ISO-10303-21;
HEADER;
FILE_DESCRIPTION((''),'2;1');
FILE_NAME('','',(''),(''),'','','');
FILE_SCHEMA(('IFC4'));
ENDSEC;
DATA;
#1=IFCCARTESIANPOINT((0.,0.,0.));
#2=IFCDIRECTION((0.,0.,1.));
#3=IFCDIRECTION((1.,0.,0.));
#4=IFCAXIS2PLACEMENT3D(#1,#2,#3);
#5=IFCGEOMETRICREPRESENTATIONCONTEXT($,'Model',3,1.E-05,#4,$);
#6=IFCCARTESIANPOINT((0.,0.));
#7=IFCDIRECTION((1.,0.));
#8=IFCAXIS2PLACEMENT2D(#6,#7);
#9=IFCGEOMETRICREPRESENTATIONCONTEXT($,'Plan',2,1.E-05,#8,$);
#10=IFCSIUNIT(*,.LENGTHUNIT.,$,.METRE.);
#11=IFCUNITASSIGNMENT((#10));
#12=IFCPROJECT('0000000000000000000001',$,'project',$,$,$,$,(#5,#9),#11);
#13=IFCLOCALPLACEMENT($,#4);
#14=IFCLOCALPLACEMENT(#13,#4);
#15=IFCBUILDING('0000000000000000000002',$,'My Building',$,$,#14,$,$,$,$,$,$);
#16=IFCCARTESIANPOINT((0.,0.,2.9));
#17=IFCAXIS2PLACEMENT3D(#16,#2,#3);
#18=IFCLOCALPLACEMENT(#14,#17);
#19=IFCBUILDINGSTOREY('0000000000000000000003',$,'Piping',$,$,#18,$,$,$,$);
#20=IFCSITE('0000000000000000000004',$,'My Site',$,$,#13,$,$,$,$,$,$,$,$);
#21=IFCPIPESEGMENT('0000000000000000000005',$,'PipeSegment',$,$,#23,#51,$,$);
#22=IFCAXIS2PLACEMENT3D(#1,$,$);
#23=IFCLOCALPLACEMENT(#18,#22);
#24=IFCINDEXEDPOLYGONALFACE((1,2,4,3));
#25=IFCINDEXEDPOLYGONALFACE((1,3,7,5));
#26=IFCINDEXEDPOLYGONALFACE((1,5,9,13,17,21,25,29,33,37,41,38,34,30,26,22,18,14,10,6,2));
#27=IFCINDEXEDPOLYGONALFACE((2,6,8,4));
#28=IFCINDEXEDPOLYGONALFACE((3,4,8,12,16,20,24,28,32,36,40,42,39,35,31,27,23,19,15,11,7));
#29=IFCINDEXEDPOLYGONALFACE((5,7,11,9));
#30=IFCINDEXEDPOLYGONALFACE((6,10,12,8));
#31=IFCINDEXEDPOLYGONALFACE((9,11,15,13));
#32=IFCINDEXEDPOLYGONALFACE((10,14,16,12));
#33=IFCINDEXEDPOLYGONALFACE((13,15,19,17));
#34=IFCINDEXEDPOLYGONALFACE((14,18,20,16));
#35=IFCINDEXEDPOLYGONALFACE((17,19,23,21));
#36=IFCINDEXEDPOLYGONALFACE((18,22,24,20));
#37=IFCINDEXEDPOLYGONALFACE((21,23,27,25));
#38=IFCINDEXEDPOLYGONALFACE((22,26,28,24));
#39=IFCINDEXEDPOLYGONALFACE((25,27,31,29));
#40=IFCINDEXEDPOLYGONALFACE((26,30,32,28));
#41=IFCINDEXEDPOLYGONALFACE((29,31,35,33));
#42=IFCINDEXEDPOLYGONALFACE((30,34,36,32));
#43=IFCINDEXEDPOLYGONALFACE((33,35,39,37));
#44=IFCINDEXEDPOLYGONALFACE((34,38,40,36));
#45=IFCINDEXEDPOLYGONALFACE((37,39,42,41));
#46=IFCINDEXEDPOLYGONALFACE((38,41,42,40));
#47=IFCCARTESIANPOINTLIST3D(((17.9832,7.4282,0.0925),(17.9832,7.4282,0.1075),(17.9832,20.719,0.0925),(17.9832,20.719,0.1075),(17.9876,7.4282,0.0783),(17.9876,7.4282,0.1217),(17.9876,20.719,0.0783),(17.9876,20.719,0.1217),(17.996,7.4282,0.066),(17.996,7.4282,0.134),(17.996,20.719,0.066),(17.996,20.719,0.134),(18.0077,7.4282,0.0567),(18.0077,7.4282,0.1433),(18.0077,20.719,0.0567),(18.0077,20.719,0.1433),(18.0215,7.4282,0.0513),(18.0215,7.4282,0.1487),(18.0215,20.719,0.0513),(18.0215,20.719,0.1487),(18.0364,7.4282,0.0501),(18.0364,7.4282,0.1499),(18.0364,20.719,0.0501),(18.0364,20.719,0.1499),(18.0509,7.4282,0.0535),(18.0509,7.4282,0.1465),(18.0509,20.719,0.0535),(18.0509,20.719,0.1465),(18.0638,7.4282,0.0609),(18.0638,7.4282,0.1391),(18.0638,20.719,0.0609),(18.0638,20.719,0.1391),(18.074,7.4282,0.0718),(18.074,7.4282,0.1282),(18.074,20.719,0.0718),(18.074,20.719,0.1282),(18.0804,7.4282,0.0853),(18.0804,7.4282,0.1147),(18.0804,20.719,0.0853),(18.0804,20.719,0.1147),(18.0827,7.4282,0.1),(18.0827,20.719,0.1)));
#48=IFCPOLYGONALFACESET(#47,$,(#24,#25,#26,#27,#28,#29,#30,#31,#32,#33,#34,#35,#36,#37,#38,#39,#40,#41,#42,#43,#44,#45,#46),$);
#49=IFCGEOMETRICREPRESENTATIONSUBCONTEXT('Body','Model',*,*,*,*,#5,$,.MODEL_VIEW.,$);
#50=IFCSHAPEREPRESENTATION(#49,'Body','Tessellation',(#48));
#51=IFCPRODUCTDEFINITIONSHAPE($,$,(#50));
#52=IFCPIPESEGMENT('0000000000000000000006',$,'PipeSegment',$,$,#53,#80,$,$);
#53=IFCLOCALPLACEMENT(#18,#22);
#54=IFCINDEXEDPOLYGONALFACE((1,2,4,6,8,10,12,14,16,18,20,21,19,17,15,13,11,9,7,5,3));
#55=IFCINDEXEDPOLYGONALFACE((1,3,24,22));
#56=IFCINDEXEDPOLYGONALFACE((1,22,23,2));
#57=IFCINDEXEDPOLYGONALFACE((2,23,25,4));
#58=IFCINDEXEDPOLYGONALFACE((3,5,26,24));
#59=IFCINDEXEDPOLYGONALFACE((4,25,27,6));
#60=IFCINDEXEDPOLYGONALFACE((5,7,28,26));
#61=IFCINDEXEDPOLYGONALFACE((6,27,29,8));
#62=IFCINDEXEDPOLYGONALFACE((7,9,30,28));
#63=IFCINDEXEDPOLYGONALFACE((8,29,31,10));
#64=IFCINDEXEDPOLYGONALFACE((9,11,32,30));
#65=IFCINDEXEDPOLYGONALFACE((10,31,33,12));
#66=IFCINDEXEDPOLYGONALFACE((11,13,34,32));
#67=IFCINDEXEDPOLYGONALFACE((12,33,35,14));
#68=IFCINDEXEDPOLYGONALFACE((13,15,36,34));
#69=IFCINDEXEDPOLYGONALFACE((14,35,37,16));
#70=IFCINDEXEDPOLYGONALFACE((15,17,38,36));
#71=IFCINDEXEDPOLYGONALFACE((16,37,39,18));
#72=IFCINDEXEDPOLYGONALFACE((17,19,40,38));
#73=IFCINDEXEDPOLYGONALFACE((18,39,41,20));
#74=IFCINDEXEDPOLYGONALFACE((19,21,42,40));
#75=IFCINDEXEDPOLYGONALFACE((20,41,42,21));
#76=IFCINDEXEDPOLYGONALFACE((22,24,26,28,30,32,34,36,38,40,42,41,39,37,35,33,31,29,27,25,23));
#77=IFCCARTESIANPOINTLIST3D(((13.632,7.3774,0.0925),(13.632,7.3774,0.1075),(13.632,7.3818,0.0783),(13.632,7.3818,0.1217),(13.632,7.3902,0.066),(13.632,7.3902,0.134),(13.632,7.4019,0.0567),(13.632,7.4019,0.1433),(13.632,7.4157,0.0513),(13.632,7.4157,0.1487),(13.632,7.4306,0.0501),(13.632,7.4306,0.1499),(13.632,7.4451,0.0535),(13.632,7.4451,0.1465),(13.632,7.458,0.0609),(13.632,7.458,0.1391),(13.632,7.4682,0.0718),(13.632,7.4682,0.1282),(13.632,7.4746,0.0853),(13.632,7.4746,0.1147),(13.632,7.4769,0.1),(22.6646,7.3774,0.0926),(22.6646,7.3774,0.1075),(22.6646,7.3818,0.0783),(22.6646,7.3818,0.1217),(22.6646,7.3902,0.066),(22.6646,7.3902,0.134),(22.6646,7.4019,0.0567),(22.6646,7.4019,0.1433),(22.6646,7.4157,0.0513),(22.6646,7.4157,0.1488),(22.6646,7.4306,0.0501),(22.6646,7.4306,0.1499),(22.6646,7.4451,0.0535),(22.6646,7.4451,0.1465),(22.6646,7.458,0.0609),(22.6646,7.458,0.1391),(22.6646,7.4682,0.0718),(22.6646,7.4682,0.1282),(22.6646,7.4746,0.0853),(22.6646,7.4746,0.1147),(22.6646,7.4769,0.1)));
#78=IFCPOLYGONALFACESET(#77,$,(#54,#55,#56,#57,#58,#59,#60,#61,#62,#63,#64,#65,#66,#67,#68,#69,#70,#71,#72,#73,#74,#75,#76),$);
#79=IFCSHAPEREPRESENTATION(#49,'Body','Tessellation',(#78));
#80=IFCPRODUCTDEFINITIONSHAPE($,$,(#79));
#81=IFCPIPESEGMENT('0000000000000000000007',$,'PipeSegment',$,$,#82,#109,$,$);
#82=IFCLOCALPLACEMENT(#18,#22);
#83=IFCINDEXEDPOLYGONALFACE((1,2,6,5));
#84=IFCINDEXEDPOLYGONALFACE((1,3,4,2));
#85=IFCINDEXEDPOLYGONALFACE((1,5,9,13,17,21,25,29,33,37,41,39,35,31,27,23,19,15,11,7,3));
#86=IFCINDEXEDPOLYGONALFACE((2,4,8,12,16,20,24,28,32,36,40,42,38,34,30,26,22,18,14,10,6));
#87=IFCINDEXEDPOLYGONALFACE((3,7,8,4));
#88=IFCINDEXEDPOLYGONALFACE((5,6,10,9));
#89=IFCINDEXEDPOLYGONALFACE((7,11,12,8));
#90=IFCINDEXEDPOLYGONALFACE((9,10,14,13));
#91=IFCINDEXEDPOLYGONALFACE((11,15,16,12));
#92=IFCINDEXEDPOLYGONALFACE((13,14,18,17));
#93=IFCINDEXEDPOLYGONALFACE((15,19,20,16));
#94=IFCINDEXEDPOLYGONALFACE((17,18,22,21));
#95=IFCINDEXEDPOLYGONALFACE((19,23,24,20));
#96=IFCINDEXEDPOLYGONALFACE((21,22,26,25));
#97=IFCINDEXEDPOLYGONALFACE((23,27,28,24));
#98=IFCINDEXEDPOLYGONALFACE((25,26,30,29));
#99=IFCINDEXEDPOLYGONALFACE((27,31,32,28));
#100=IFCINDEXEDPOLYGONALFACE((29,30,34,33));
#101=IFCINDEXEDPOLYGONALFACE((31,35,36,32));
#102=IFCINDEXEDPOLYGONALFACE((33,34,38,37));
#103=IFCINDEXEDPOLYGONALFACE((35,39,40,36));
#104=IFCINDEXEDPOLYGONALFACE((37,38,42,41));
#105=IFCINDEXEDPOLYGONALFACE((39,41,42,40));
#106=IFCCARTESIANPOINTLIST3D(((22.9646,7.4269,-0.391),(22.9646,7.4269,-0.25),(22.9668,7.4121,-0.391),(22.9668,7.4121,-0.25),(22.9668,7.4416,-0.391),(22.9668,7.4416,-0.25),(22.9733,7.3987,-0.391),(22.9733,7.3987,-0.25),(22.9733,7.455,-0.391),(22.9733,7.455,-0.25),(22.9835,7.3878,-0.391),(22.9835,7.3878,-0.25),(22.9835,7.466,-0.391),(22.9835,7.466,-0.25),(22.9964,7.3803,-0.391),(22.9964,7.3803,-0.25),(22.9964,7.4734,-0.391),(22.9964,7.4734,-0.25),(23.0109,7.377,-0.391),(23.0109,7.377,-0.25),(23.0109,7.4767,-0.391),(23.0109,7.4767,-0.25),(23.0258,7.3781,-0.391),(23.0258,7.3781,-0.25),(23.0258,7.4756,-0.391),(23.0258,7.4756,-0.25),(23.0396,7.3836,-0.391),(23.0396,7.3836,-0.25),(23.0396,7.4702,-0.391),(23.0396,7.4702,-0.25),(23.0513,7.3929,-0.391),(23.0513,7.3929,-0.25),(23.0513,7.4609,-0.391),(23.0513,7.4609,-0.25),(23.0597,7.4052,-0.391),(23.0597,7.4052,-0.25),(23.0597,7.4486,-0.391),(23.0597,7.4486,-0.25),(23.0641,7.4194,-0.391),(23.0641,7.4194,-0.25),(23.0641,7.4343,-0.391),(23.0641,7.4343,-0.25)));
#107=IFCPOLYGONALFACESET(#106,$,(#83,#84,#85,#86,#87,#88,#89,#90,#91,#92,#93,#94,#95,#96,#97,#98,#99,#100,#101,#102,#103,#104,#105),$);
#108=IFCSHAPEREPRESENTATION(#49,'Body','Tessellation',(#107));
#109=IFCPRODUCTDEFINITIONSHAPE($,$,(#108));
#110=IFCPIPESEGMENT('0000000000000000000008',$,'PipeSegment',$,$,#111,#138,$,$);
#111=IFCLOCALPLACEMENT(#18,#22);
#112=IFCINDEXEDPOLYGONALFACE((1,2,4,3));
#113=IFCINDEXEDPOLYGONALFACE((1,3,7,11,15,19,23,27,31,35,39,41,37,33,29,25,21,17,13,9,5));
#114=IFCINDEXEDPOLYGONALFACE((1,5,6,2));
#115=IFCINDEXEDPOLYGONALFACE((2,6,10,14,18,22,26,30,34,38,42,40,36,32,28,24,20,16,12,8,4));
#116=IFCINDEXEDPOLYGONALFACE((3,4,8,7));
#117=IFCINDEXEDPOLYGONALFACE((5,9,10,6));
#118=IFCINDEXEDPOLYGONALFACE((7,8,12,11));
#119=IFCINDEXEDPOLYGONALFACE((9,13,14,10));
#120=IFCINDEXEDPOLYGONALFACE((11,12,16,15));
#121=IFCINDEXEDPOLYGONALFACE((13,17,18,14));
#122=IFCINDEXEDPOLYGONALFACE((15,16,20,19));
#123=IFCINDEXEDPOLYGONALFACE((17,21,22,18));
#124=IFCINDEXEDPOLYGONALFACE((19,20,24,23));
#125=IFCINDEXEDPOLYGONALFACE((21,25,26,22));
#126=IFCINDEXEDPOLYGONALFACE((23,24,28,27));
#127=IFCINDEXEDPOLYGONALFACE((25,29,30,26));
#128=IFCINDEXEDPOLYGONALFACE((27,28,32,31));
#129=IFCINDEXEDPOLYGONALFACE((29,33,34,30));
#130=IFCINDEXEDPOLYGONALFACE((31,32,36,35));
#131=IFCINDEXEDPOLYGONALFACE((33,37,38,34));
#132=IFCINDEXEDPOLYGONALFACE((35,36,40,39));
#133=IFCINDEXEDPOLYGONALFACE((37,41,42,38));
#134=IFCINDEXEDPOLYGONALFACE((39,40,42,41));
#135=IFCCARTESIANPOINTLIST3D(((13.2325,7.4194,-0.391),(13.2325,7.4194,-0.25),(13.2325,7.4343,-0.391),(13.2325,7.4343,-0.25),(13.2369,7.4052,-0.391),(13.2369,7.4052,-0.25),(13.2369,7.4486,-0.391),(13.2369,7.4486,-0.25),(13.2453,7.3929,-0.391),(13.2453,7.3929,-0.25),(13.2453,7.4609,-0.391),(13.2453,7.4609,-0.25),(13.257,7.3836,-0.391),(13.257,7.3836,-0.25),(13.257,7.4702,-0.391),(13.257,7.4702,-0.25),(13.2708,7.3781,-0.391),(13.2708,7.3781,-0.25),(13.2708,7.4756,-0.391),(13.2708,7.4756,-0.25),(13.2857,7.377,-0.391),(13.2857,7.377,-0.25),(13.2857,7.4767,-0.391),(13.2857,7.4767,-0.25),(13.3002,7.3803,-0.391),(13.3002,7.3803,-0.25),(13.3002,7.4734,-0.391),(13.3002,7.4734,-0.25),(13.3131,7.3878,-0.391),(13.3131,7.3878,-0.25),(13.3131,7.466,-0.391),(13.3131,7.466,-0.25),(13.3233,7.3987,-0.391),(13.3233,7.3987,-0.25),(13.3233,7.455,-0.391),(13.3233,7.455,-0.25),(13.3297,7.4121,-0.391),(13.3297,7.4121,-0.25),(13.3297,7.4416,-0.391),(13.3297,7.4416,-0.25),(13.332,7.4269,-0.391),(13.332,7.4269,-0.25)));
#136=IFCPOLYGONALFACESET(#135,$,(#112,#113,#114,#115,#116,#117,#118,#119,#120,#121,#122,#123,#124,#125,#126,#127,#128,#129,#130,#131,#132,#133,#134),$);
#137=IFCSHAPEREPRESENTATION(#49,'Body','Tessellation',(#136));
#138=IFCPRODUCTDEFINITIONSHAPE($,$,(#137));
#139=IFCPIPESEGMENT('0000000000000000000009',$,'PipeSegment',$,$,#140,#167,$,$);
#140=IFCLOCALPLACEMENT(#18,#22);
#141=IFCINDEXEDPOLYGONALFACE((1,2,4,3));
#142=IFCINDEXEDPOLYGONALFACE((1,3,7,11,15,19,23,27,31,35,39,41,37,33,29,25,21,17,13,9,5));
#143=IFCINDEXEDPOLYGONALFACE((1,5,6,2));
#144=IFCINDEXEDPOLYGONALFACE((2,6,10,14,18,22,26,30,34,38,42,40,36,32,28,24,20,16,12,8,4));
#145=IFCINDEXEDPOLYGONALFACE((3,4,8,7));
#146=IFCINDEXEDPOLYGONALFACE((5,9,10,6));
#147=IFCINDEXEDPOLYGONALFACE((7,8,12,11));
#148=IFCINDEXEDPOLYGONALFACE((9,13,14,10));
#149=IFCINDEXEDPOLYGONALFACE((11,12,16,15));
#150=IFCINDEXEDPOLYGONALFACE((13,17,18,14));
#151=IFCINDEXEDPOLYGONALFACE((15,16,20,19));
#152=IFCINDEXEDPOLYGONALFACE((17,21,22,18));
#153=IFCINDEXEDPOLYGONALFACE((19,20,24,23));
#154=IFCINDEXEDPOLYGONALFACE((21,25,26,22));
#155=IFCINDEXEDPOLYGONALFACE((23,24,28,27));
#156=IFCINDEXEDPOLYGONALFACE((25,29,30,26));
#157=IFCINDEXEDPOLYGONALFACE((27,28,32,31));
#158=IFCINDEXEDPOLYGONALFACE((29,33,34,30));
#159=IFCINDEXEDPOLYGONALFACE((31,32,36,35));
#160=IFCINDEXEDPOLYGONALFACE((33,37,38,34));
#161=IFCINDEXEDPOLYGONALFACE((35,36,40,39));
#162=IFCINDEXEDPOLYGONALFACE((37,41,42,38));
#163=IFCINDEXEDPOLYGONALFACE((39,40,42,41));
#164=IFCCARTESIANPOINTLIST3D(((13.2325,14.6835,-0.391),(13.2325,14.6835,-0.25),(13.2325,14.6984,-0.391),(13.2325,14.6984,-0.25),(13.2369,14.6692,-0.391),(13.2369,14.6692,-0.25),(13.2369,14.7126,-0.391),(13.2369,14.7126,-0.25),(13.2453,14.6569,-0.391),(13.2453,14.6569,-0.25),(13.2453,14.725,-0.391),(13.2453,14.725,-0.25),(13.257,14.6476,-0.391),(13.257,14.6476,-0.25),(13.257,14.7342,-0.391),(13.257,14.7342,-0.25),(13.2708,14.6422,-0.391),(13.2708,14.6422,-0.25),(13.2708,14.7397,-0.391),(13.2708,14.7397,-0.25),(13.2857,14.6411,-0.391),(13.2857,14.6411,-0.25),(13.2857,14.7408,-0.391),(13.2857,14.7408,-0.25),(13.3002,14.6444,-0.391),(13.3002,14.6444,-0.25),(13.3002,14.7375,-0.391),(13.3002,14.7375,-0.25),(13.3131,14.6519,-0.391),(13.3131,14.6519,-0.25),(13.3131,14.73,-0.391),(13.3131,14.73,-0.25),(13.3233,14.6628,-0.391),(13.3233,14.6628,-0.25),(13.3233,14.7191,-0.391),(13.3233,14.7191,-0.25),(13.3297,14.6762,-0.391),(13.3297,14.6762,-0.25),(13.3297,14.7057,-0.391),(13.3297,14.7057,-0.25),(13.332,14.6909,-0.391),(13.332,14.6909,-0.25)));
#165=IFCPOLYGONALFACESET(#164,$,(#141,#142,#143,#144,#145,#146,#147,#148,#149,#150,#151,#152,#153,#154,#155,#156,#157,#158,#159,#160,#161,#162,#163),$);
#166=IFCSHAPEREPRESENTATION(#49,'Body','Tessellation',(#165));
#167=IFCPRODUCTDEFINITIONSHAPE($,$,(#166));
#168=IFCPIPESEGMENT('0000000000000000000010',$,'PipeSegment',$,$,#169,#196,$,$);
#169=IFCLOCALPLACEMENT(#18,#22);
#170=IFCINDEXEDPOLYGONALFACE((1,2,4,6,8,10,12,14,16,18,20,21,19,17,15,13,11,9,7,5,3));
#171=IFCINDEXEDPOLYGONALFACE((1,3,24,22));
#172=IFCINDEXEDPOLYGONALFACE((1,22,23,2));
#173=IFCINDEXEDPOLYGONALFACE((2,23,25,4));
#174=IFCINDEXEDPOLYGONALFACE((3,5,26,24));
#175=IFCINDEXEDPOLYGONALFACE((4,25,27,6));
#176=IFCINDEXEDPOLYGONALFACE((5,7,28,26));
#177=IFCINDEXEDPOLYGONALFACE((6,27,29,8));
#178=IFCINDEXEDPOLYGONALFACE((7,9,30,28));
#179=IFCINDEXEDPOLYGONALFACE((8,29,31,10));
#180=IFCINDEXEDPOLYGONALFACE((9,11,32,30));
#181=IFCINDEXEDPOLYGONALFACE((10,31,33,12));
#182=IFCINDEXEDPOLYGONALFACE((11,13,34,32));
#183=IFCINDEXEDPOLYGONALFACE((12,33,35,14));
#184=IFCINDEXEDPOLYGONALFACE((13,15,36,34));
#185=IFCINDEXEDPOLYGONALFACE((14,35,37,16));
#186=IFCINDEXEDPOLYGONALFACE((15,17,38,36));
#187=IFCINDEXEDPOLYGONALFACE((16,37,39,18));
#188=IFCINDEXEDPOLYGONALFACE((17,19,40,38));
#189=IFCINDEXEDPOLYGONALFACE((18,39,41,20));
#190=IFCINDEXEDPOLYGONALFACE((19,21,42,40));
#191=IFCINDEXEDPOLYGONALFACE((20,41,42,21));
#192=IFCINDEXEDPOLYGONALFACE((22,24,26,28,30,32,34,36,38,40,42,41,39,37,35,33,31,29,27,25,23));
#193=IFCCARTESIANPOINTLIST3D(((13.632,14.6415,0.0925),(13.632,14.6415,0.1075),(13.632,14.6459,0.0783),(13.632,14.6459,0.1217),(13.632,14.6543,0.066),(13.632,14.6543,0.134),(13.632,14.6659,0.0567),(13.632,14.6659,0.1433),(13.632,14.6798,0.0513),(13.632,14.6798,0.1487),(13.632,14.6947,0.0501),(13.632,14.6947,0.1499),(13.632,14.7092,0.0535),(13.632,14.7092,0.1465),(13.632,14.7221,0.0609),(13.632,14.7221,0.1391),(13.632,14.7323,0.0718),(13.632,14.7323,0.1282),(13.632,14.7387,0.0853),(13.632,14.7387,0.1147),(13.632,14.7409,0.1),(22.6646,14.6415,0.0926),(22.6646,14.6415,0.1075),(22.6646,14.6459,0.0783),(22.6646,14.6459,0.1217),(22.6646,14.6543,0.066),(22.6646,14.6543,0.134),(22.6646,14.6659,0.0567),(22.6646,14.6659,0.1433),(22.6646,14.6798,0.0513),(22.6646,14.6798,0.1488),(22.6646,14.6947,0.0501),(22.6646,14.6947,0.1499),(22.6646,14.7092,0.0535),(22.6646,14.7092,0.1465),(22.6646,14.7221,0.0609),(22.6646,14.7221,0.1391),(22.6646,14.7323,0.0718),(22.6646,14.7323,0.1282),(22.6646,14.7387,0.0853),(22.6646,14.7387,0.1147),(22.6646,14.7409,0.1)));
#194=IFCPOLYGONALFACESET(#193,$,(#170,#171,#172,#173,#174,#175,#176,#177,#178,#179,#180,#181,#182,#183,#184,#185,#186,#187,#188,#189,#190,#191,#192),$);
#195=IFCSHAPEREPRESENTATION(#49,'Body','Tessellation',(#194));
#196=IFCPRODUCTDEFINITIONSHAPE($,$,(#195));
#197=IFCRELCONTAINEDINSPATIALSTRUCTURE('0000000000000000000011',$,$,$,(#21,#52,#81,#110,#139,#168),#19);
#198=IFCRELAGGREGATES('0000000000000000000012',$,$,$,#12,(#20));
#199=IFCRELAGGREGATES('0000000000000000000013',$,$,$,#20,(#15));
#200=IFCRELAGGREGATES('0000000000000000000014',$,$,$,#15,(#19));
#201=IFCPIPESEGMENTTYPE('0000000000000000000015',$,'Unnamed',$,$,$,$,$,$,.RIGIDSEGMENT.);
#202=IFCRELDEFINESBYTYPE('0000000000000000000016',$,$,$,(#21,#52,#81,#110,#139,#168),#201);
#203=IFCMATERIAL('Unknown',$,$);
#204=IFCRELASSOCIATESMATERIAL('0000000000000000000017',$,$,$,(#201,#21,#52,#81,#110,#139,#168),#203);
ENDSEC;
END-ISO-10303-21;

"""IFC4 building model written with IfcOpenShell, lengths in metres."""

from ifc_helpers import new_model, si_unit, frame, origin_with_axes, origin_2d_with_axis, place, context, subcontext, project, spatial, circle, extrude, material, material_profile, profile_set, profile_usage, type_object, element, save


model = new_model("IFC4")

# Units and contexts
model_context = context("Model", 3, precision=1e-05, world=origin_with_axes())
plan_context = context("Plan", 2, precision=1e-05, world=origin_2d_with_axis())
body_context = subcontext(model_context, "Body", "Model", "MODEL_VIEW")
ifc_project = project(units=[si_unit("LENGTHUNIT", "METRE")], contexts=[model_context, plan_context])

# Site, building, storey
site_placement = place(None, origin_with_axes())
site = spatial("IfcSite", under=ifc_project, at=site_placement, Name="My Site")
building_placement = place(site_placement, origin_with_axes())
building = spatial("IfcBuilding", under=site, at=building_placement, Name="My Building")
storey_placement = place(building_placement, frame((0.0, 0.0, 2.9), z_axis=(0.0, 0.0, 1.0), x_axis=(1.0, 0.0, 0.0)))
storey = spatial("IfcBuildingStorey", under=building, at=storey_placement, Name="Piping")

# Pipe segments
ifc_material = material(Name="Unknown")
ifc_material_profile = material_profile(ifc_material, circle(Radius=0.05))
ifc_profile_set = profile_set([ifc_material_profile])
ifc_profile_usage_1 = profile_usage(ifc_profile_set, cardinal=5)
pipe_segment_type = type_object("IfcPipeSegmentType", Name="Unnamed", PredefinedType="RIGIDSEGMENT", material=ifc_profile_set)
pipe_segment_1_placement = place(storey_placement, frame((18.0327, 20.719, 0.1), z_axis=(0.0, -1.0, 0.0), x_axis=(1.0, 0.0, 0.0)))
element("IfcPipeSegment", 1, at=pipe_segment_1_placement, inside=storey, type_object=pipe_segment_type, material=ifc_profile_usage_1, Name="PipeSegment", context=body_context, shape_type="SweptSolid", body=[
    extrude(circle(Radius=0.05), origin_with_axes(), (0.0, 0.0, 1.0), 13.2908),
])
ifc_profile_usage_2 = profile_usage(ifc_profile_set, cardinal=5)
pipe_segment_2_placement = place(storey_placement, frame((13.632, 7.4269, 0.1), z_axis=(1.0, -0.000001, 0.000001), x_axis=(0.000001, 1.0, 0.0)))
element("IfcPipeSegment", 2, at=pipe_segment_2_placement, inside=storey, type_object=pipe_segment_type, material=ifc_profile_usage_2, Name="PipeSegment", context=body_context, shape_type="SweptSolid", body=[
    extrude(circle(Radius=0.05), origin_with_axes(), (0.0, 0.0, 1.0), 9.0327),
])
ifc_profile_usage_3 = profile_usage(ifc_profile_set, cardinal=5)
pipe_segment_3_placement = place(storey_placement, frame((23.0146, 7.4269, -0.25), z_axis=(0.0, 0.0, -1.0), x_axis=(-1.0, 0.0, 0.0)))
element("IfcPipeSegment", 3, at=pipe_segment_3_placement, inside=storey, type_object=pipe_segment_type, material=ifc_profile_usage_3, Name="PipeSegment", context=body_context, shape_type="SweptSolid", body=[
    extrude(circle(Radius=0.05), origin_with_axes(), (0.0, 0.0, 1.0), 0.141),
])
ifc_profile_usage_4 = profile_usage(ifc_profile_set, cardinal=5)
pipe_segment_4_placement = place(storey_placement, frame((13.282, 7.4269, -0.25), z_axis=(0.0, 0.0, -1.0), x_axis=(1.0, 0.0, 0.0)))
element("IfcPipeSegment", 4, at=pipe_segment_4_placement, inside=storey, type_object=pipe_segment_type, material=ifc_profile_usage_4, Name="PipeSegment", context=body_context, shape_type="SweptSolid", body=[
    extrude(circle(Radius=0.05), origin_with_axes(), (0.0, 0.0, 1.0), 0.141),
])
ifc_profile_usage_5 = profile_usage(ifc_profile_set, cardinal=5)
pipe_segment_5_placement = place(storey_placement, frame((13.282, 14.6909, -0.25), z_axis=(0.0, 0.0, -1.0), x_axis=(1.0, 0.0, 0.0)))
element("IfcPipeSegment", 5, at=pipe_segment_5_placement, inside=storey, type_object=pipe_segment_type, material=ifc_profile_usage_5, Name="PipeSegment", context=body_context, shape_type="SweptSolid", body=[
    extrude(circle(Radius=0.05), origin_with_axes(), (0.0, 0.0, 1.0), 0.141),
])
ifc_profile_usage_6 = profile_usage(ifc_profile_set, cardinal=5)
pipe_segment_6_placement = place(storey_placement, frame((13.632, 14.6909, 0.1), z_axis=(1.0, -0.000001, 0.000001), x_axis=(0.000001, 1.0, 0.0)))
element("IfcPipeSegment", 6, at=pipe_segment_6_placement, inside=storey, type_object=pipe_segment_type, material=ifc_profile_usage_6, Name="PipeSegment", context=body_context, shape_type="SweptSolid", body=[
    extrude(circle(Radius=0.05), origin_with_axes(), (0.0, 0.0, 1.0), 9.0327),
])

save(model, "model.ifc")
